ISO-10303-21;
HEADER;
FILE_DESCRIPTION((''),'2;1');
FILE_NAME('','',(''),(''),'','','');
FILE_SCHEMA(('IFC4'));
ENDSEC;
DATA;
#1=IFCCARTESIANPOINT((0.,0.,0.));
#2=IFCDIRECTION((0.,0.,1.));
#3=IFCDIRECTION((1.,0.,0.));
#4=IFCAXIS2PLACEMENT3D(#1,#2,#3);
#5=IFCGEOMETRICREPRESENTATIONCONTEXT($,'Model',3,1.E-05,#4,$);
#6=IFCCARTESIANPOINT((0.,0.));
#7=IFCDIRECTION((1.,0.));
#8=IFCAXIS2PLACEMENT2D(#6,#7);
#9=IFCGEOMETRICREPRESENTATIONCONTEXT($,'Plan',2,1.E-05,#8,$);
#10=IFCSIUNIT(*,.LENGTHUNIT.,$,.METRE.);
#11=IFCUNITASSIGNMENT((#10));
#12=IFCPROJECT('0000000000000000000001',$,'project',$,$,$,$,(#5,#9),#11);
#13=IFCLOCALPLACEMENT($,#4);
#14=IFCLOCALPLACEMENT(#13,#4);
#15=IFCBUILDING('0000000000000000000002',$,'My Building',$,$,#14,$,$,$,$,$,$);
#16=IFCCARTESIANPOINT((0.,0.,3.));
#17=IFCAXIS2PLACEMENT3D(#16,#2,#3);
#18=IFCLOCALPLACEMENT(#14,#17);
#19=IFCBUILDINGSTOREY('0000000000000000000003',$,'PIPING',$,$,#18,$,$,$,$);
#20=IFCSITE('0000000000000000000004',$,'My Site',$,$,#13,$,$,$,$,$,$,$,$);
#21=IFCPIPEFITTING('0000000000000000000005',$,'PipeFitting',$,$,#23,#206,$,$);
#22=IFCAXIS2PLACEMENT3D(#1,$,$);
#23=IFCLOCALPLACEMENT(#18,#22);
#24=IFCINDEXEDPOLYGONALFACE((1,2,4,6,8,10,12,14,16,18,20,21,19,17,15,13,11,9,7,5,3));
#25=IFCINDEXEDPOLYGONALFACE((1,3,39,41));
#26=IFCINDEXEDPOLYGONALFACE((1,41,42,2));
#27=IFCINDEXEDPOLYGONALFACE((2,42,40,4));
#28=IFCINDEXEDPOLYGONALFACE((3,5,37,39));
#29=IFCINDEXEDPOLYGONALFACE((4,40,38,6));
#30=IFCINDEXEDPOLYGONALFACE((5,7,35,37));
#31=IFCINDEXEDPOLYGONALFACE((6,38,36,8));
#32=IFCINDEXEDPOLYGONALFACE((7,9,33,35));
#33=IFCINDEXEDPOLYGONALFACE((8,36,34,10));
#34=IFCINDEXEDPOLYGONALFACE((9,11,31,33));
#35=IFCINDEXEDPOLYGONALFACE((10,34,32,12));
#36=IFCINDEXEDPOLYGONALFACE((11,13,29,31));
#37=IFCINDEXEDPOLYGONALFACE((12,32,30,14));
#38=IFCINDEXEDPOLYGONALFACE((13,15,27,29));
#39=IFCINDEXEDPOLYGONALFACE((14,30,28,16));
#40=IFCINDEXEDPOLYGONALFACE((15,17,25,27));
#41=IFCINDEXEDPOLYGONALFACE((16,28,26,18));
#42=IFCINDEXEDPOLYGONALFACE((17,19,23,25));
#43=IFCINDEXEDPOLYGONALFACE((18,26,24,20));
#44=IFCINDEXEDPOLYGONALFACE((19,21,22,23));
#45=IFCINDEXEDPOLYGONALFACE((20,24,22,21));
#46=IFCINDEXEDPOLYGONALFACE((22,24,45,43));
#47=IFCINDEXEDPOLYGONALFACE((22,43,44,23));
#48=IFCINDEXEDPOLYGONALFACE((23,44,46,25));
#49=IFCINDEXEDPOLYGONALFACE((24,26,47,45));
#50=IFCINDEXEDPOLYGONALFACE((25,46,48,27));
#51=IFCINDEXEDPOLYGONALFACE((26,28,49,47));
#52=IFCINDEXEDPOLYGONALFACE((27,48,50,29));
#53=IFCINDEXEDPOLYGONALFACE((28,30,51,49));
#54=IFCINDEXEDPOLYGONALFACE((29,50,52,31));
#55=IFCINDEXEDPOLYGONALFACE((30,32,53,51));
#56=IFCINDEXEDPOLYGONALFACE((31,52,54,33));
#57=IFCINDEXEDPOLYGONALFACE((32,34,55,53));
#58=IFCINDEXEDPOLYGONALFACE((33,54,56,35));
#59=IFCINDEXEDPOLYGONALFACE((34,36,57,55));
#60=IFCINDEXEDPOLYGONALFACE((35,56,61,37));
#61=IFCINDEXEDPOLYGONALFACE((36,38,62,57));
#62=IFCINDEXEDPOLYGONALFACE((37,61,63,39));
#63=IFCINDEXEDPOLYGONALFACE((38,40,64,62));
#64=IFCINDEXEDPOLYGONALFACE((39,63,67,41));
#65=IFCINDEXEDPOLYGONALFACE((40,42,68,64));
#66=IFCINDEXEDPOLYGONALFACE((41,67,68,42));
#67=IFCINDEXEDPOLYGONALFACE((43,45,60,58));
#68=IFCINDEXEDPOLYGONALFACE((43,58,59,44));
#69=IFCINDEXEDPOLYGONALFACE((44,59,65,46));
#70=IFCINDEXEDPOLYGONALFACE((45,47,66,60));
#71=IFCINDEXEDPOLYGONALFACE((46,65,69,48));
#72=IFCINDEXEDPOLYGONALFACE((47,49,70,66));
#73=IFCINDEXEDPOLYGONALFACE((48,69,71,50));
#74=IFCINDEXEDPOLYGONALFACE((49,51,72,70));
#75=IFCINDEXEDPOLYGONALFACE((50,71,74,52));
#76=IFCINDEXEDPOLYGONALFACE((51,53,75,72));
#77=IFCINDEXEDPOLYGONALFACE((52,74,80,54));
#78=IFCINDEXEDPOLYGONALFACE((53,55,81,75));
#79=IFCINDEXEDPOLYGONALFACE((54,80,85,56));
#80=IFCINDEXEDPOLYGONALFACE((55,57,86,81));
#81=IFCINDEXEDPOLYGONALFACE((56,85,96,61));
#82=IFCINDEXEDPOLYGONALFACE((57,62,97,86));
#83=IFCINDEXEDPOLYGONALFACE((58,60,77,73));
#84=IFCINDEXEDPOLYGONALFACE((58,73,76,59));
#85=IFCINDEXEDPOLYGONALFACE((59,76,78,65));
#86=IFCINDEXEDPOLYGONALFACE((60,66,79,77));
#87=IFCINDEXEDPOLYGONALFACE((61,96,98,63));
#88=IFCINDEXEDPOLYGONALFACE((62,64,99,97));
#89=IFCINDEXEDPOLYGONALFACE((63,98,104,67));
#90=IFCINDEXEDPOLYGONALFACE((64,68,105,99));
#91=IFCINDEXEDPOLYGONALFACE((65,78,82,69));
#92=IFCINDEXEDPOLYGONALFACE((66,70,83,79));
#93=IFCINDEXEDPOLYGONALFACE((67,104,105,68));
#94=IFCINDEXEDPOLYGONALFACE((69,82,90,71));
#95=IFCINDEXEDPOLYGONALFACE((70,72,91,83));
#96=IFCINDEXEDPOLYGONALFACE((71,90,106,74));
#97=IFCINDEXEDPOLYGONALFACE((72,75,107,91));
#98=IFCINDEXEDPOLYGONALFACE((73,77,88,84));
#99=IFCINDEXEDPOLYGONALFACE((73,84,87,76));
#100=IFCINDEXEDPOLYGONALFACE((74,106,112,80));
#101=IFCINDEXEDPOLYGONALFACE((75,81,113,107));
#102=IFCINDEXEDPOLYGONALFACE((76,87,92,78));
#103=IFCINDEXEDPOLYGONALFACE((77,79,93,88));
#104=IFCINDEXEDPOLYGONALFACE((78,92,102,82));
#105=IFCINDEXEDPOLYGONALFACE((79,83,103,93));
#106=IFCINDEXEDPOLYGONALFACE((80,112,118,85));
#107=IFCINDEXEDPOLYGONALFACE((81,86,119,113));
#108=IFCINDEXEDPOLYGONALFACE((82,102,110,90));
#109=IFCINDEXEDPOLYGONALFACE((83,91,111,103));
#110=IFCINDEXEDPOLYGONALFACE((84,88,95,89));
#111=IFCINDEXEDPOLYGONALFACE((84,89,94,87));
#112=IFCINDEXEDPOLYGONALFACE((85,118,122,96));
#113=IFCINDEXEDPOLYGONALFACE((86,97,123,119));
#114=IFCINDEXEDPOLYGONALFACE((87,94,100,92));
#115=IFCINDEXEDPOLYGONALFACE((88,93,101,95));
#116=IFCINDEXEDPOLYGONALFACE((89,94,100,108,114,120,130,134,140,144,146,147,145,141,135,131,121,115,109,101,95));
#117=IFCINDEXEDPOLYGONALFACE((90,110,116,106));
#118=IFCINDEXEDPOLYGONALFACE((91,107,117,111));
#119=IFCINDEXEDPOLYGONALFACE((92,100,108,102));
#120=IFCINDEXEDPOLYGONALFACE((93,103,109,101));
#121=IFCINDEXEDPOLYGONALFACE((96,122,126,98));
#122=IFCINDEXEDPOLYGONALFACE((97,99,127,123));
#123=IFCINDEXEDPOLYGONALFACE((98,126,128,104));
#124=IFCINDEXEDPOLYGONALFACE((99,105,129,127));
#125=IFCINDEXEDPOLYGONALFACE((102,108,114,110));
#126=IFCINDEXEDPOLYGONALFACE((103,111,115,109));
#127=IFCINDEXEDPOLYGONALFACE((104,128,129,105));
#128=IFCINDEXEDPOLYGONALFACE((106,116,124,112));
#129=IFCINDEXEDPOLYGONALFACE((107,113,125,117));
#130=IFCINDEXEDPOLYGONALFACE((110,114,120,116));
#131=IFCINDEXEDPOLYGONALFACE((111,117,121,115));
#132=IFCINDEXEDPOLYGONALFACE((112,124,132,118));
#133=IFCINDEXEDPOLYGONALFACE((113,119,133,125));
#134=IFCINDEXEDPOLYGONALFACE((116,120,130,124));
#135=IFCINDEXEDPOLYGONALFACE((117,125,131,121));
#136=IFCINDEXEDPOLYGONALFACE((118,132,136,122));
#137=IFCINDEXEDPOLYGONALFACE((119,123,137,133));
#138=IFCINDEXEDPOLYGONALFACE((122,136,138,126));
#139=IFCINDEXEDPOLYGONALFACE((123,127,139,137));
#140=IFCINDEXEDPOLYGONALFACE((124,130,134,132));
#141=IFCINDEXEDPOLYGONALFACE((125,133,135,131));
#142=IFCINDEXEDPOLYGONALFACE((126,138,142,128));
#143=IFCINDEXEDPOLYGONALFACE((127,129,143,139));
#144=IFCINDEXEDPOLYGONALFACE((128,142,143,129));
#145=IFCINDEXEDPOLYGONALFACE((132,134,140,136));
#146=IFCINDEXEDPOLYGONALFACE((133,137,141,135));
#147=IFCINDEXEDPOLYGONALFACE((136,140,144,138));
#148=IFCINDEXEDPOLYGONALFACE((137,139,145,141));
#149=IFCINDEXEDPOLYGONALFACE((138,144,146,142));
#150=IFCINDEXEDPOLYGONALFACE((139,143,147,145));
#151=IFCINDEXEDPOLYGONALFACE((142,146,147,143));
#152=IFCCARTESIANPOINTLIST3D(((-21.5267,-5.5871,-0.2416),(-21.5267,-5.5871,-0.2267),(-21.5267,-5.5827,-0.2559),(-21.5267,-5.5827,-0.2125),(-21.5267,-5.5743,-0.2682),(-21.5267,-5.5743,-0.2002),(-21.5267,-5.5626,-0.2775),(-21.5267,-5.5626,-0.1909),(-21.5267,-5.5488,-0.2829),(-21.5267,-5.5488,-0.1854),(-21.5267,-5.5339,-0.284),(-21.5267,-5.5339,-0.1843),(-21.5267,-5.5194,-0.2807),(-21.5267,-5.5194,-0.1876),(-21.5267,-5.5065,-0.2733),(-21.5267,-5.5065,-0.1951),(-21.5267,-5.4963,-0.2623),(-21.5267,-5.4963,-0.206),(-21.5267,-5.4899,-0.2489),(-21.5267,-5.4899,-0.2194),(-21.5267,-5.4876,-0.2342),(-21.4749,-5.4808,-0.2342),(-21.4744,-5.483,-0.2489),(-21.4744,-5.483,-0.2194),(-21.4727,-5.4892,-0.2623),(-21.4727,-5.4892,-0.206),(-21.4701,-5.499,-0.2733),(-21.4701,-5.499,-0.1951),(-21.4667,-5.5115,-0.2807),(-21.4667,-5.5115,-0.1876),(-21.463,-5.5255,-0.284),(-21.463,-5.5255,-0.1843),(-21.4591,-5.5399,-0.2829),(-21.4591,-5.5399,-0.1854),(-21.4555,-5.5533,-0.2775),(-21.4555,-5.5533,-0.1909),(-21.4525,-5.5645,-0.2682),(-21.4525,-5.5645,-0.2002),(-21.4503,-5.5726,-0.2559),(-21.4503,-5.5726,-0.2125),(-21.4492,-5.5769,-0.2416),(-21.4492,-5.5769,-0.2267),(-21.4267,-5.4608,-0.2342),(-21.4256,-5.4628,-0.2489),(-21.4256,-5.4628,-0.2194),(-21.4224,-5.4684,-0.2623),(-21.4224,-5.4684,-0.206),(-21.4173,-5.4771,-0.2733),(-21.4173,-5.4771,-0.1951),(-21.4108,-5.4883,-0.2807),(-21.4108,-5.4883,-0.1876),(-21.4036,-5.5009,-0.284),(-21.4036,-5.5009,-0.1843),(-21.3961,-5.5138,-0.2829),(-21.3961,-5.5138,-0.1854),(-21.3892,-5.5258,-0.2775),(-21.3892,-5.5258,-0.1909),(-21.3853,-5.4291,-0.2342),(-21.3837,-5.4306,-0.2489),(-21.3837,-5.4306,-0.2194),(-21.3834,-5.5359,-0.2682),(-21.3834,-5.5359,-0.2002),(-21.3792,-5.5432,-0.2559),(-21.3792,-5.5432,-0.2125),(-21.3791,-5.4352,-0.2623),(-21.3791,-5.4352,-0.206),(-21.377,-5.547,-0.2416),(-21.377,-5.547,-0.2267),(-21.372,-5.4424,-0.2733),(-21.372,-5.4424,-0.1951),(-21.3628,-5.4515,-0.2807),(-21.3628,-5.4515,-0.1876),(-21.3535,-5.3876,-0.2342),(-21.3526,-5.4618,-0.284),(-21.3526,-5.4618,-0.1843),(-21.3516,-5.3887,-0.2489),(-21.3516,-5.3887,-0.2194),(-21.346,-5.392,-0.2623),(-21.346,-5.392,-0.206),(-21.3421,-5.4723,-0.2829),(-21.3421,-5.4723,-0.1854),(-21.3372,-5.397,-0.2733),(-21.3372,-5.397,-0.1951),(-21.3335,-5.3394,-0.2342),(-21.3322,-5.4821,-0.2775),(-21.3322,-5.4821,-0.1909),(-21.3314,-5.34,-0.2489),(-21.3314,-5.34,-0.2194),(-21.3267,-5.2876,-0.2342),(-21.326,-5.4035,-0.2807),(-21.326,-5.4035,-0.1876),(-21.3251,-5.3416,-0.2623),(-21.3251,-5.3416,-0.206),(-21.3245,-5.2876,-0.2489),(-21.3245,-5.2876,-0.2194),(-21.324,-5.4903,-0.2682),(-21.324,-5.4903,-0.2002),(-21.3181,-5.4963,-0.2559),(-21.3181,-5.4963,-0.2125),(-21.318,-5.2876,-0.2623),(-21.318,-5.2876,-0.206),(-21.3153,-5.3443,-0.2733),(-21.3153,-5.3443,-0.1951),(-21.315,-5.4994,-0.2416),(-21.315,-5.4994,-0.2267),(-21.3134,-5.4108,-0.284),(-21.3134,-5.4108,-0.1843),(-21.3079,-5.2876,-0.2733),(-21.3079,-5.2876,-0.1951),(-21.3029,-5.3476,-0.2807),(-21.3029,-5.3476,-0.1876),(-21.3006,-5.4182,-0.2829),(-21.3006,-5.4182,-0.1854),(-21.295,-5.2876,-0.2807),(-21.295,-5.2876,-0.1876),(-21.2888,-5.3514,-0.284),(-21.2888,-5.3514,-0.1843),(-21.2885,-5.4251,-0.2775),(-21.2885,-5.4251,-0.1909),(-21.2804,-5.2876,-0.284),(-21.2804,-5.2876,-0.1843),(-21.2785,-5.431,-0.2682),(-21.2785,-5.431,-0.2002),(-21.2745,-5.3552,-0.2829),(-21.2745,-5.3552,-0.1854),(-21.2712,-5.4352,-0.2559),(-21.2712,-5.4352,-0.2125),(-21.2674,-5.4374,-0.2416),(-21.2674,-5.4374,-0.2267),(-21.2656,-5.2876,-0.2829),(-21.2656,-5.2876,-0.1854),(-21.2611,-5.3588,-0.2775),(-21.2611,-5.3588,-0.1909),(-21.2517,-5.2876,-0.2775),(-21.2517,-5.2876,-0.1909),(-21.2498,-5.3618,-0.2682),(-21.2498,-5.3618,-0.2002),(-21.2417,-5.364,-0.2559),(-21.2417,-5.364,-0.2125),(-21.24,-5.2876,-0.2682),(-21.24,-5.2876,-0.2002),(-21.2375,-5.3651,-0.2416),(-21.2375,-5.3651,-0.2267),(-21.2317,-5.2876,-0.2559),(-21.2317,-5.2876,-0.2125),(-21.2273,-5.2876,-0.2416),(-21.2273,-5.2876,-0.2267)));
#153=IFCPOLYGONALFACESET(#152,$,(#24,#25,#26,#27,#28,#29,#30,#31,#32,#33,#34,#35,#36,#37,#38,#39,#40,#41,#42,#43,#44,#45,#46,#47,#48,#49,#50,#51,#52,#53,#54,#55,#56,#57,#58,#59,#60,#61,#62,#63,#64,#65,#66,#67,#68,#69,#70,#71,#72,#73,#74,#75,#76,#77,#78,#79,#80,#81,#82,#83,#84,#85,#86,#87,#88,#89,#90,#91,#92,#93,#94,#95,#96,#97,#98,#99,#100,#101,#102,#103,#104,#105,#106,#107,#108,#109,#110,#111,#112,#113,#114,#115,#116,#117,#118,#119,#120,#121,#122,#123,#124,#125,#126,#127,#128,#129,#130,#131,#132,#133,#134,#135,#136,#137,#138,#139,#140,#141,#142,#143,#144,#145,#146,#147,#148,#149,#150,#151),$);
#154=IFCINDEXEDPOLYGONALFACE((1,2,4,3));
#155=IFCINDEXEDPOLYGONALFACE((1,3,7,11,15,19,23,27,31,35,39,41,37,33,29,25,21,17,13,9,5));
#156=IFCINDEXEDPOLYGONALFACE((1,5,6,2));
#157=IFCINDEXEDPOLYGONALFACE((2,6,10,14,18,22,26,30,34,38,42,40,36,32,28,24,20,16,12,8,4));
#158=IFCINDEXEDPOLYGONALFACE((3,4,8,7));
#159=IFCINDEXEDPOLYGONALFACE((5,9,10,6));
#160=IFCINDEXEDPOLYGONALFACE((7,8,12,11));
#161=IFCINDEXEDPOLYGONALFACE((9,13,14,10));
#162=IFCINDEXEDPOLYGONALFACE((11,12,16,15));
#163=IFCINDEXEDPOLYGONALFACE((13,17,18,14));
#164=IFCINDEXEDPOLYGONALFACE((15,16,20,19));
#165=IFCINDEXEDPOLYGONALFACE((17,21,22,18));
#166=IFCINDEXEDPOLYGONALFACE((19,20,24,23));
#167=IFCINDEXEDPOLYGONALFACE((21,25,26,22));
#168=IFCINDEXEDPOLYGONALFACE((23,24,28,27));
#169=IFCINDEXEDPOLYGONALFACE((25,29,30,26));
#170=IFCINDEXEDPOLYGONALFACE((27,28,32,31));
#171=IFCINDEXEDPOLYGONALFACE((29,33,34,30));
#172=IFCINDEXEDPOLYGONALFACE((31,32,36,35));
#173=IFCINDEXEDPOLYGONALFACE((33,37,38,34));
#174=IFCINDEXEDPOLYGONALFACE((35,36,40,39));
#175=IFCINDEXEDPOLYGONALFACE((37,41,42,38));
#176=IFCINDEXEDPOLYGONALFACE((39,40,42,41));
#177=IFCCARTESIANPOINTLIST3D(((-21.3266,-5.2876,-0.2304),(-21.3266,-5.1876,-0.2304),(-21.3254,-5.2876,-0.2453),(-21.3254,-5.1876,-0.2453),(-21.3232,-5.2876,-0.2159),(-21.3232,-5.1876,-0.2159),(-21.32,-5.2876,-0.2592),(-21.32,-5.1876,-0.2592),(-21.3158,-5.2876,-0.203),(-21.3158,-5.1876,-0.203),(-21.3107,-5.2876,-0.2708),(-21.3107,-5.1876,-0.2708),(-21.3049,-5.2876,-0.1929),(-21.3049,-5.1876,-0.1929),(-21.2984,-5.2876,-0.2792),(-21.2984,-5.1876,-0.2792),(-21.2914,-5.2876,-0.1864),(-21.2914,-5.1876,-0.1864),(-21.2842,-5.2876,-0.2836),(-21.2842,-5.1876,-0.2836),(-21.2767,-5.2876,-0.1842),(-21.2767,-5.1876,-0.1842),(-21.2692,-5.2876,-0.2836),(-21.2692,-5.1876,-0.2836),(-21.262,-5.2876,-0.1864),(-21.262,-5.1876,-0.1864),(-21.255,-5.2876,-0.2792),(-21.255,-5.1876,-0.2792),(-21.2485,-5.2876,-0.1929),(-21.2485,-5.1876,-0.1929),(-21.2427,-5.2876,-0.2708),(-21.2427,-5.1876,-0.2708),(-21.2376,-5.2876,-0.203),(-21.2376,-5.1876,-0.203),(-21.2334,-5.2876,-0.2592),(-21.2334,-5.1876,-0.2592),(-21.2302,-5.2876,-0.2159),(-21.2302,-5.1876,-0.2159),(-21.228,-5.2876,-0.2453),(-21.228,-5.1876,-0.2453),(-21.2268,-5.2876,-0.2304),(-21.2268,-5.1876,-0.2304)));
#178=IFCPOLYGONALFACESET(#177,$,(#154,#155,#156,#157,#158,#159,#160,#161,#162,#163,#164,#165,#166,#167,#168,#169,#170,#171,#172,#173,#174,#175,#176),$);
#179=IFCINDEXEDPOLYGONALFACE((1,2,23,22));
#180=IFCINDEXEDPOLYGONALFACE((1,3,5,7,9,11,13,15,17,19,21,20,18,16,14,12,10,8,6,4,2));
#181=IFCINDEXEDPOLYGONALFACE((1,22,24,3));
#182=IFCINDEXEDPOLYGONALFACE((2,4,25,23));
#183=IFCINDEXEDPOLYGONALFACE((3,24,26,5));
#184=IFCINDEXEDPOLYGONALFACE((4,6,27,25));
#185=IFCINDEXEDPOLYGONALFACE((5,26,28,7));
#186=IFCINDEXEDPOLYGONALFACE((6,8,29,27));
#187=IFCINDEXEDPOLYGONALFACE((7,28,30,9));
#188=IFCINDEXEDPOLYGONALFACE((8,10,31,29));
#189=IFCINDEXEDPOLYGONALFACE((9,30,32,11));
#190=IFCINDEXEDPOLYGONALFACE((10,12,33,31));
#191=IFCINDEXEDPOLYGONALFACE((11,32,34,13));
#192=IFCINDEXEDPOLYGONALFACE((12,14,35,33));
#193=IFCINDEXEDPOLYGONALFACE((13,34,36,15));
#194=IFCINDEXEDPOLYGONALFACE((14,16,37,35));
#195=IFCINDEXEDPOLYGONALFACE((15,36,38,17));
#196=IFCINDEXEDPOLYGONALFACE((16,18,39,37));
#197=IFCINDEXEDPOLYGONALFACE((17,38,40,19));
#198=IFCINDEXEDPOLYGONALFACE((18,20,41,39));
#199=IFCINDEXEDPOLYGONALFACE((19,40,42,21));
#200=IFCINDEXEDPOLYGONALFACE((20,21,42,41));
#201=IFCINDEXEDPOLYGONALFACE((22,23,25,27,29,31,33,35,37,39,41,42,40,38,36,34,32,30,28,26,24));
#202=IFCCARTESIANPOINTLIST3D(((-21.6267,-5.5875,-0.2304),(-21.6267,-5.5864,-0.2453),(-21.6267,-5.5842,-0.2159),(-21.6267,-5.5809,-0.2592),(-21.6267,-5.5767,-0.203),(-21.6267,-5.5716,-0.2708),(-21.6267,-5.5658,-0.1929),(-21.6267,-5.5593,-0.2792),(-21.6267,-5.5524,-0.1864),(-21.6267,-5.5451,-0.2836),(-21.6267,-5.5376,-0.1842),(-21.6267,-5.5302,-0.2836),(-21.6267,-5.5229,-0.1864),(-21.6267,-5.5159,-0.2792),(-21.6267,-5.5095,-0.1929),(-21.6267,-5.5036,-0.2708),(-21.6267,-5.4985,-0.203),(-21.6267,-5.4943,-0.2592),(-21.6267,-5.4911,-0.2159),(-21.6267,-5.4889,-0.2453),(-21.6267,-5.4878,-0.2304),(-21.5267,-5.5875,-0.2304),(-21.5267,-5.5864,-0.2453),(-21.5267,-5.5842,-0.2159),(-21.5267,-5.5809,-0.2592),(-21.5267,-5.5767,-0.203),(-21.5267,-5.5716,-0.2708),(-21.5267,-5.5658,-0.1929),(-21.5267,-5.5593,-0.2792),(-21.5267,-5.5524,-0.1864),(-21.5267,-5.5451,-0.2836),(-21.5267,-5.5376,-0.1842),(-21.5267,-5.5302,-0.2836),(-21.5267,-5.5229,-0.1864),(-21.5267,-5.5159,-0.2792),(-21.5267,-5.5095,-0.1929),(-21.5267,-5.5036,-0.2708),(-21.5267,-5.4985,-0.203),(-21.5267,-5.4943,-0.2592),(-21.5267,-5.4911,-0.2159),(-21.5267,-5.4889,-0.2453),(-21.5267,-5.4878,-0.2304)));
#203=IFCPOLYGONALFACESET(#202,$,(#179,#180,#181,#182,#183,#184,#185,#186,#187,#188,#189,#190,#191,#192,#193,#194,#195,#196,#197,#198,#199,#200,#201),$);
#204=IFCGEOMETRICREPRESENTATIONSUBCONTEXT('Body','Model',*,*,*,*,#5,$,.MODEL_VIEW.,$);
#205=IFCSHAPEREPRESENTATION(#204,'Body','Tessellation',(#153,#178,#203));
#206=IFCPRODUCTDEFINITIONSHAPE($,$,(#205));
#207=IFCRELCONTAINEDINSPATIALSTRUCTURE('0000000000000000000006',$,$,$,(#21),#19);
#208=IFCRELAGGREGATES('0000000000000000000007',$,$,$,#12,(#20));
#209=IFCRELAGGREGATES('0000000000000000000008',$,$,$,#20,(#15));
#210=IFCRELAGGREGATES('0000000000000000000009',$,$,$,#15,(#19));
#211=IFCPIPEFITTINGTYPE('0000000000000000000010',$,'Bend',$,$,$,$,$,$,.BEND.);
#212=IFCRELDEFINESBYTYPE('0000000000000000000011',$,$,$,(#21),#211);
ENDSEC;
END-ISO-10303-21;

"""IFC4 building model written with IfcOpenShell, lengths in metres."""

from ifc_helpers import new_model, entity, si_unit, frame, origin_with_axes, origin_2d_with_axis, place, context, subcontext, project, spatial, circle, extrude, source, transform, mapped, type_object, type_shapes, element, save


model = new_model("IFC4")

# Units and contexts
model_context = context("Model", 3, precision=1e-05, world=origin_with_axes())
plan_context = context("Plan", 2, precision=1e-05, world=origin_2d_with_axis())
body_context = subcontext(model_context, "Body", "Model", "MODEL_VIEW")
ifc_project = project(units=[si_unit("LENGTHUNIT", "METRE")], contexts=[model_context, plan_context])

# Site, building, storey
site_placement = place(None, origin_with_axes())
site = spatial("IfcSite", under=ifc_project, at=site_placement, Name="My Site")
building_placement = place(site_placement, origin_with_axes())
building = spatial("IfcBuilding", under=site, at=building_placement, Name="My Building")
storey_placement = place(building_placement, frame((0.0, 0.0, 3.0), z_axis=(0.0, 0.0, 1.0), x_axis=(1.0, 0.0, 0.0)))
storey = spatial("IfcBuildingStorey", under=building, at=storey_placement, Name="PIPING")

# Pipe fitting
pipe_fitting_type = type_object("IfcPipeFittingType", Name="Bend", PredefinedType="BEND")
shared_shape = source(origin_with_axes(), body_context, "Body", "SolidModel", [
    entity("IfcSweptDiskSolid", entity("IfcIndexedPolyCurve", entity("IfcCartesianPointList3D", [[0.0, 0.0, -0.1], [0.0, -0.0732, -0.2768], [0.0, -0.25, -0.35]]), [entity("IfcArcIndex", [1, 2, 3])]), 0.05),
    extrude(circle(Radius=0.05), origin_with_axes(), (0.0, 0.0, -1.0), 0.1),
    extrude(circle(Radius=0.05), frame((0.0, -0.25, -0.35), z_axis=(0.0, -1.0, 0.0), x_axis=(1.0, 0.0, 0.0)), (0.0, 0.0, 1.0), 0.1),
])
type_shapes(pipe_fitting_type, [shared_shape])
for number, where, z_axis, x_axis, name in (
    (1, (-21.2767, -5.1876, -0.2342), (0.0, 1.0, 0.0), (0.0, 0.0, 1.0), "PipeFitting"),
):
    element("IfcPipeFitting", number, at=place(storey_placement, frame(where, z_axis=z_axis, x_axis=x_axis)), inside=storey, type_object=pipe_fitting_type, Name=name, context=body_context, shape_type="MappedRepresentation", body=[
        mapped(shared_shape, transform((0.0, 0.0, 0.0), x_axis=(1.0, 0.0, 0.0), y_axis=(0.0, 1.0, 0.0), z_axis=(0.0, 0.0, 1.0), scale=1.0)),
    ])

save(model, "model.ifc")
